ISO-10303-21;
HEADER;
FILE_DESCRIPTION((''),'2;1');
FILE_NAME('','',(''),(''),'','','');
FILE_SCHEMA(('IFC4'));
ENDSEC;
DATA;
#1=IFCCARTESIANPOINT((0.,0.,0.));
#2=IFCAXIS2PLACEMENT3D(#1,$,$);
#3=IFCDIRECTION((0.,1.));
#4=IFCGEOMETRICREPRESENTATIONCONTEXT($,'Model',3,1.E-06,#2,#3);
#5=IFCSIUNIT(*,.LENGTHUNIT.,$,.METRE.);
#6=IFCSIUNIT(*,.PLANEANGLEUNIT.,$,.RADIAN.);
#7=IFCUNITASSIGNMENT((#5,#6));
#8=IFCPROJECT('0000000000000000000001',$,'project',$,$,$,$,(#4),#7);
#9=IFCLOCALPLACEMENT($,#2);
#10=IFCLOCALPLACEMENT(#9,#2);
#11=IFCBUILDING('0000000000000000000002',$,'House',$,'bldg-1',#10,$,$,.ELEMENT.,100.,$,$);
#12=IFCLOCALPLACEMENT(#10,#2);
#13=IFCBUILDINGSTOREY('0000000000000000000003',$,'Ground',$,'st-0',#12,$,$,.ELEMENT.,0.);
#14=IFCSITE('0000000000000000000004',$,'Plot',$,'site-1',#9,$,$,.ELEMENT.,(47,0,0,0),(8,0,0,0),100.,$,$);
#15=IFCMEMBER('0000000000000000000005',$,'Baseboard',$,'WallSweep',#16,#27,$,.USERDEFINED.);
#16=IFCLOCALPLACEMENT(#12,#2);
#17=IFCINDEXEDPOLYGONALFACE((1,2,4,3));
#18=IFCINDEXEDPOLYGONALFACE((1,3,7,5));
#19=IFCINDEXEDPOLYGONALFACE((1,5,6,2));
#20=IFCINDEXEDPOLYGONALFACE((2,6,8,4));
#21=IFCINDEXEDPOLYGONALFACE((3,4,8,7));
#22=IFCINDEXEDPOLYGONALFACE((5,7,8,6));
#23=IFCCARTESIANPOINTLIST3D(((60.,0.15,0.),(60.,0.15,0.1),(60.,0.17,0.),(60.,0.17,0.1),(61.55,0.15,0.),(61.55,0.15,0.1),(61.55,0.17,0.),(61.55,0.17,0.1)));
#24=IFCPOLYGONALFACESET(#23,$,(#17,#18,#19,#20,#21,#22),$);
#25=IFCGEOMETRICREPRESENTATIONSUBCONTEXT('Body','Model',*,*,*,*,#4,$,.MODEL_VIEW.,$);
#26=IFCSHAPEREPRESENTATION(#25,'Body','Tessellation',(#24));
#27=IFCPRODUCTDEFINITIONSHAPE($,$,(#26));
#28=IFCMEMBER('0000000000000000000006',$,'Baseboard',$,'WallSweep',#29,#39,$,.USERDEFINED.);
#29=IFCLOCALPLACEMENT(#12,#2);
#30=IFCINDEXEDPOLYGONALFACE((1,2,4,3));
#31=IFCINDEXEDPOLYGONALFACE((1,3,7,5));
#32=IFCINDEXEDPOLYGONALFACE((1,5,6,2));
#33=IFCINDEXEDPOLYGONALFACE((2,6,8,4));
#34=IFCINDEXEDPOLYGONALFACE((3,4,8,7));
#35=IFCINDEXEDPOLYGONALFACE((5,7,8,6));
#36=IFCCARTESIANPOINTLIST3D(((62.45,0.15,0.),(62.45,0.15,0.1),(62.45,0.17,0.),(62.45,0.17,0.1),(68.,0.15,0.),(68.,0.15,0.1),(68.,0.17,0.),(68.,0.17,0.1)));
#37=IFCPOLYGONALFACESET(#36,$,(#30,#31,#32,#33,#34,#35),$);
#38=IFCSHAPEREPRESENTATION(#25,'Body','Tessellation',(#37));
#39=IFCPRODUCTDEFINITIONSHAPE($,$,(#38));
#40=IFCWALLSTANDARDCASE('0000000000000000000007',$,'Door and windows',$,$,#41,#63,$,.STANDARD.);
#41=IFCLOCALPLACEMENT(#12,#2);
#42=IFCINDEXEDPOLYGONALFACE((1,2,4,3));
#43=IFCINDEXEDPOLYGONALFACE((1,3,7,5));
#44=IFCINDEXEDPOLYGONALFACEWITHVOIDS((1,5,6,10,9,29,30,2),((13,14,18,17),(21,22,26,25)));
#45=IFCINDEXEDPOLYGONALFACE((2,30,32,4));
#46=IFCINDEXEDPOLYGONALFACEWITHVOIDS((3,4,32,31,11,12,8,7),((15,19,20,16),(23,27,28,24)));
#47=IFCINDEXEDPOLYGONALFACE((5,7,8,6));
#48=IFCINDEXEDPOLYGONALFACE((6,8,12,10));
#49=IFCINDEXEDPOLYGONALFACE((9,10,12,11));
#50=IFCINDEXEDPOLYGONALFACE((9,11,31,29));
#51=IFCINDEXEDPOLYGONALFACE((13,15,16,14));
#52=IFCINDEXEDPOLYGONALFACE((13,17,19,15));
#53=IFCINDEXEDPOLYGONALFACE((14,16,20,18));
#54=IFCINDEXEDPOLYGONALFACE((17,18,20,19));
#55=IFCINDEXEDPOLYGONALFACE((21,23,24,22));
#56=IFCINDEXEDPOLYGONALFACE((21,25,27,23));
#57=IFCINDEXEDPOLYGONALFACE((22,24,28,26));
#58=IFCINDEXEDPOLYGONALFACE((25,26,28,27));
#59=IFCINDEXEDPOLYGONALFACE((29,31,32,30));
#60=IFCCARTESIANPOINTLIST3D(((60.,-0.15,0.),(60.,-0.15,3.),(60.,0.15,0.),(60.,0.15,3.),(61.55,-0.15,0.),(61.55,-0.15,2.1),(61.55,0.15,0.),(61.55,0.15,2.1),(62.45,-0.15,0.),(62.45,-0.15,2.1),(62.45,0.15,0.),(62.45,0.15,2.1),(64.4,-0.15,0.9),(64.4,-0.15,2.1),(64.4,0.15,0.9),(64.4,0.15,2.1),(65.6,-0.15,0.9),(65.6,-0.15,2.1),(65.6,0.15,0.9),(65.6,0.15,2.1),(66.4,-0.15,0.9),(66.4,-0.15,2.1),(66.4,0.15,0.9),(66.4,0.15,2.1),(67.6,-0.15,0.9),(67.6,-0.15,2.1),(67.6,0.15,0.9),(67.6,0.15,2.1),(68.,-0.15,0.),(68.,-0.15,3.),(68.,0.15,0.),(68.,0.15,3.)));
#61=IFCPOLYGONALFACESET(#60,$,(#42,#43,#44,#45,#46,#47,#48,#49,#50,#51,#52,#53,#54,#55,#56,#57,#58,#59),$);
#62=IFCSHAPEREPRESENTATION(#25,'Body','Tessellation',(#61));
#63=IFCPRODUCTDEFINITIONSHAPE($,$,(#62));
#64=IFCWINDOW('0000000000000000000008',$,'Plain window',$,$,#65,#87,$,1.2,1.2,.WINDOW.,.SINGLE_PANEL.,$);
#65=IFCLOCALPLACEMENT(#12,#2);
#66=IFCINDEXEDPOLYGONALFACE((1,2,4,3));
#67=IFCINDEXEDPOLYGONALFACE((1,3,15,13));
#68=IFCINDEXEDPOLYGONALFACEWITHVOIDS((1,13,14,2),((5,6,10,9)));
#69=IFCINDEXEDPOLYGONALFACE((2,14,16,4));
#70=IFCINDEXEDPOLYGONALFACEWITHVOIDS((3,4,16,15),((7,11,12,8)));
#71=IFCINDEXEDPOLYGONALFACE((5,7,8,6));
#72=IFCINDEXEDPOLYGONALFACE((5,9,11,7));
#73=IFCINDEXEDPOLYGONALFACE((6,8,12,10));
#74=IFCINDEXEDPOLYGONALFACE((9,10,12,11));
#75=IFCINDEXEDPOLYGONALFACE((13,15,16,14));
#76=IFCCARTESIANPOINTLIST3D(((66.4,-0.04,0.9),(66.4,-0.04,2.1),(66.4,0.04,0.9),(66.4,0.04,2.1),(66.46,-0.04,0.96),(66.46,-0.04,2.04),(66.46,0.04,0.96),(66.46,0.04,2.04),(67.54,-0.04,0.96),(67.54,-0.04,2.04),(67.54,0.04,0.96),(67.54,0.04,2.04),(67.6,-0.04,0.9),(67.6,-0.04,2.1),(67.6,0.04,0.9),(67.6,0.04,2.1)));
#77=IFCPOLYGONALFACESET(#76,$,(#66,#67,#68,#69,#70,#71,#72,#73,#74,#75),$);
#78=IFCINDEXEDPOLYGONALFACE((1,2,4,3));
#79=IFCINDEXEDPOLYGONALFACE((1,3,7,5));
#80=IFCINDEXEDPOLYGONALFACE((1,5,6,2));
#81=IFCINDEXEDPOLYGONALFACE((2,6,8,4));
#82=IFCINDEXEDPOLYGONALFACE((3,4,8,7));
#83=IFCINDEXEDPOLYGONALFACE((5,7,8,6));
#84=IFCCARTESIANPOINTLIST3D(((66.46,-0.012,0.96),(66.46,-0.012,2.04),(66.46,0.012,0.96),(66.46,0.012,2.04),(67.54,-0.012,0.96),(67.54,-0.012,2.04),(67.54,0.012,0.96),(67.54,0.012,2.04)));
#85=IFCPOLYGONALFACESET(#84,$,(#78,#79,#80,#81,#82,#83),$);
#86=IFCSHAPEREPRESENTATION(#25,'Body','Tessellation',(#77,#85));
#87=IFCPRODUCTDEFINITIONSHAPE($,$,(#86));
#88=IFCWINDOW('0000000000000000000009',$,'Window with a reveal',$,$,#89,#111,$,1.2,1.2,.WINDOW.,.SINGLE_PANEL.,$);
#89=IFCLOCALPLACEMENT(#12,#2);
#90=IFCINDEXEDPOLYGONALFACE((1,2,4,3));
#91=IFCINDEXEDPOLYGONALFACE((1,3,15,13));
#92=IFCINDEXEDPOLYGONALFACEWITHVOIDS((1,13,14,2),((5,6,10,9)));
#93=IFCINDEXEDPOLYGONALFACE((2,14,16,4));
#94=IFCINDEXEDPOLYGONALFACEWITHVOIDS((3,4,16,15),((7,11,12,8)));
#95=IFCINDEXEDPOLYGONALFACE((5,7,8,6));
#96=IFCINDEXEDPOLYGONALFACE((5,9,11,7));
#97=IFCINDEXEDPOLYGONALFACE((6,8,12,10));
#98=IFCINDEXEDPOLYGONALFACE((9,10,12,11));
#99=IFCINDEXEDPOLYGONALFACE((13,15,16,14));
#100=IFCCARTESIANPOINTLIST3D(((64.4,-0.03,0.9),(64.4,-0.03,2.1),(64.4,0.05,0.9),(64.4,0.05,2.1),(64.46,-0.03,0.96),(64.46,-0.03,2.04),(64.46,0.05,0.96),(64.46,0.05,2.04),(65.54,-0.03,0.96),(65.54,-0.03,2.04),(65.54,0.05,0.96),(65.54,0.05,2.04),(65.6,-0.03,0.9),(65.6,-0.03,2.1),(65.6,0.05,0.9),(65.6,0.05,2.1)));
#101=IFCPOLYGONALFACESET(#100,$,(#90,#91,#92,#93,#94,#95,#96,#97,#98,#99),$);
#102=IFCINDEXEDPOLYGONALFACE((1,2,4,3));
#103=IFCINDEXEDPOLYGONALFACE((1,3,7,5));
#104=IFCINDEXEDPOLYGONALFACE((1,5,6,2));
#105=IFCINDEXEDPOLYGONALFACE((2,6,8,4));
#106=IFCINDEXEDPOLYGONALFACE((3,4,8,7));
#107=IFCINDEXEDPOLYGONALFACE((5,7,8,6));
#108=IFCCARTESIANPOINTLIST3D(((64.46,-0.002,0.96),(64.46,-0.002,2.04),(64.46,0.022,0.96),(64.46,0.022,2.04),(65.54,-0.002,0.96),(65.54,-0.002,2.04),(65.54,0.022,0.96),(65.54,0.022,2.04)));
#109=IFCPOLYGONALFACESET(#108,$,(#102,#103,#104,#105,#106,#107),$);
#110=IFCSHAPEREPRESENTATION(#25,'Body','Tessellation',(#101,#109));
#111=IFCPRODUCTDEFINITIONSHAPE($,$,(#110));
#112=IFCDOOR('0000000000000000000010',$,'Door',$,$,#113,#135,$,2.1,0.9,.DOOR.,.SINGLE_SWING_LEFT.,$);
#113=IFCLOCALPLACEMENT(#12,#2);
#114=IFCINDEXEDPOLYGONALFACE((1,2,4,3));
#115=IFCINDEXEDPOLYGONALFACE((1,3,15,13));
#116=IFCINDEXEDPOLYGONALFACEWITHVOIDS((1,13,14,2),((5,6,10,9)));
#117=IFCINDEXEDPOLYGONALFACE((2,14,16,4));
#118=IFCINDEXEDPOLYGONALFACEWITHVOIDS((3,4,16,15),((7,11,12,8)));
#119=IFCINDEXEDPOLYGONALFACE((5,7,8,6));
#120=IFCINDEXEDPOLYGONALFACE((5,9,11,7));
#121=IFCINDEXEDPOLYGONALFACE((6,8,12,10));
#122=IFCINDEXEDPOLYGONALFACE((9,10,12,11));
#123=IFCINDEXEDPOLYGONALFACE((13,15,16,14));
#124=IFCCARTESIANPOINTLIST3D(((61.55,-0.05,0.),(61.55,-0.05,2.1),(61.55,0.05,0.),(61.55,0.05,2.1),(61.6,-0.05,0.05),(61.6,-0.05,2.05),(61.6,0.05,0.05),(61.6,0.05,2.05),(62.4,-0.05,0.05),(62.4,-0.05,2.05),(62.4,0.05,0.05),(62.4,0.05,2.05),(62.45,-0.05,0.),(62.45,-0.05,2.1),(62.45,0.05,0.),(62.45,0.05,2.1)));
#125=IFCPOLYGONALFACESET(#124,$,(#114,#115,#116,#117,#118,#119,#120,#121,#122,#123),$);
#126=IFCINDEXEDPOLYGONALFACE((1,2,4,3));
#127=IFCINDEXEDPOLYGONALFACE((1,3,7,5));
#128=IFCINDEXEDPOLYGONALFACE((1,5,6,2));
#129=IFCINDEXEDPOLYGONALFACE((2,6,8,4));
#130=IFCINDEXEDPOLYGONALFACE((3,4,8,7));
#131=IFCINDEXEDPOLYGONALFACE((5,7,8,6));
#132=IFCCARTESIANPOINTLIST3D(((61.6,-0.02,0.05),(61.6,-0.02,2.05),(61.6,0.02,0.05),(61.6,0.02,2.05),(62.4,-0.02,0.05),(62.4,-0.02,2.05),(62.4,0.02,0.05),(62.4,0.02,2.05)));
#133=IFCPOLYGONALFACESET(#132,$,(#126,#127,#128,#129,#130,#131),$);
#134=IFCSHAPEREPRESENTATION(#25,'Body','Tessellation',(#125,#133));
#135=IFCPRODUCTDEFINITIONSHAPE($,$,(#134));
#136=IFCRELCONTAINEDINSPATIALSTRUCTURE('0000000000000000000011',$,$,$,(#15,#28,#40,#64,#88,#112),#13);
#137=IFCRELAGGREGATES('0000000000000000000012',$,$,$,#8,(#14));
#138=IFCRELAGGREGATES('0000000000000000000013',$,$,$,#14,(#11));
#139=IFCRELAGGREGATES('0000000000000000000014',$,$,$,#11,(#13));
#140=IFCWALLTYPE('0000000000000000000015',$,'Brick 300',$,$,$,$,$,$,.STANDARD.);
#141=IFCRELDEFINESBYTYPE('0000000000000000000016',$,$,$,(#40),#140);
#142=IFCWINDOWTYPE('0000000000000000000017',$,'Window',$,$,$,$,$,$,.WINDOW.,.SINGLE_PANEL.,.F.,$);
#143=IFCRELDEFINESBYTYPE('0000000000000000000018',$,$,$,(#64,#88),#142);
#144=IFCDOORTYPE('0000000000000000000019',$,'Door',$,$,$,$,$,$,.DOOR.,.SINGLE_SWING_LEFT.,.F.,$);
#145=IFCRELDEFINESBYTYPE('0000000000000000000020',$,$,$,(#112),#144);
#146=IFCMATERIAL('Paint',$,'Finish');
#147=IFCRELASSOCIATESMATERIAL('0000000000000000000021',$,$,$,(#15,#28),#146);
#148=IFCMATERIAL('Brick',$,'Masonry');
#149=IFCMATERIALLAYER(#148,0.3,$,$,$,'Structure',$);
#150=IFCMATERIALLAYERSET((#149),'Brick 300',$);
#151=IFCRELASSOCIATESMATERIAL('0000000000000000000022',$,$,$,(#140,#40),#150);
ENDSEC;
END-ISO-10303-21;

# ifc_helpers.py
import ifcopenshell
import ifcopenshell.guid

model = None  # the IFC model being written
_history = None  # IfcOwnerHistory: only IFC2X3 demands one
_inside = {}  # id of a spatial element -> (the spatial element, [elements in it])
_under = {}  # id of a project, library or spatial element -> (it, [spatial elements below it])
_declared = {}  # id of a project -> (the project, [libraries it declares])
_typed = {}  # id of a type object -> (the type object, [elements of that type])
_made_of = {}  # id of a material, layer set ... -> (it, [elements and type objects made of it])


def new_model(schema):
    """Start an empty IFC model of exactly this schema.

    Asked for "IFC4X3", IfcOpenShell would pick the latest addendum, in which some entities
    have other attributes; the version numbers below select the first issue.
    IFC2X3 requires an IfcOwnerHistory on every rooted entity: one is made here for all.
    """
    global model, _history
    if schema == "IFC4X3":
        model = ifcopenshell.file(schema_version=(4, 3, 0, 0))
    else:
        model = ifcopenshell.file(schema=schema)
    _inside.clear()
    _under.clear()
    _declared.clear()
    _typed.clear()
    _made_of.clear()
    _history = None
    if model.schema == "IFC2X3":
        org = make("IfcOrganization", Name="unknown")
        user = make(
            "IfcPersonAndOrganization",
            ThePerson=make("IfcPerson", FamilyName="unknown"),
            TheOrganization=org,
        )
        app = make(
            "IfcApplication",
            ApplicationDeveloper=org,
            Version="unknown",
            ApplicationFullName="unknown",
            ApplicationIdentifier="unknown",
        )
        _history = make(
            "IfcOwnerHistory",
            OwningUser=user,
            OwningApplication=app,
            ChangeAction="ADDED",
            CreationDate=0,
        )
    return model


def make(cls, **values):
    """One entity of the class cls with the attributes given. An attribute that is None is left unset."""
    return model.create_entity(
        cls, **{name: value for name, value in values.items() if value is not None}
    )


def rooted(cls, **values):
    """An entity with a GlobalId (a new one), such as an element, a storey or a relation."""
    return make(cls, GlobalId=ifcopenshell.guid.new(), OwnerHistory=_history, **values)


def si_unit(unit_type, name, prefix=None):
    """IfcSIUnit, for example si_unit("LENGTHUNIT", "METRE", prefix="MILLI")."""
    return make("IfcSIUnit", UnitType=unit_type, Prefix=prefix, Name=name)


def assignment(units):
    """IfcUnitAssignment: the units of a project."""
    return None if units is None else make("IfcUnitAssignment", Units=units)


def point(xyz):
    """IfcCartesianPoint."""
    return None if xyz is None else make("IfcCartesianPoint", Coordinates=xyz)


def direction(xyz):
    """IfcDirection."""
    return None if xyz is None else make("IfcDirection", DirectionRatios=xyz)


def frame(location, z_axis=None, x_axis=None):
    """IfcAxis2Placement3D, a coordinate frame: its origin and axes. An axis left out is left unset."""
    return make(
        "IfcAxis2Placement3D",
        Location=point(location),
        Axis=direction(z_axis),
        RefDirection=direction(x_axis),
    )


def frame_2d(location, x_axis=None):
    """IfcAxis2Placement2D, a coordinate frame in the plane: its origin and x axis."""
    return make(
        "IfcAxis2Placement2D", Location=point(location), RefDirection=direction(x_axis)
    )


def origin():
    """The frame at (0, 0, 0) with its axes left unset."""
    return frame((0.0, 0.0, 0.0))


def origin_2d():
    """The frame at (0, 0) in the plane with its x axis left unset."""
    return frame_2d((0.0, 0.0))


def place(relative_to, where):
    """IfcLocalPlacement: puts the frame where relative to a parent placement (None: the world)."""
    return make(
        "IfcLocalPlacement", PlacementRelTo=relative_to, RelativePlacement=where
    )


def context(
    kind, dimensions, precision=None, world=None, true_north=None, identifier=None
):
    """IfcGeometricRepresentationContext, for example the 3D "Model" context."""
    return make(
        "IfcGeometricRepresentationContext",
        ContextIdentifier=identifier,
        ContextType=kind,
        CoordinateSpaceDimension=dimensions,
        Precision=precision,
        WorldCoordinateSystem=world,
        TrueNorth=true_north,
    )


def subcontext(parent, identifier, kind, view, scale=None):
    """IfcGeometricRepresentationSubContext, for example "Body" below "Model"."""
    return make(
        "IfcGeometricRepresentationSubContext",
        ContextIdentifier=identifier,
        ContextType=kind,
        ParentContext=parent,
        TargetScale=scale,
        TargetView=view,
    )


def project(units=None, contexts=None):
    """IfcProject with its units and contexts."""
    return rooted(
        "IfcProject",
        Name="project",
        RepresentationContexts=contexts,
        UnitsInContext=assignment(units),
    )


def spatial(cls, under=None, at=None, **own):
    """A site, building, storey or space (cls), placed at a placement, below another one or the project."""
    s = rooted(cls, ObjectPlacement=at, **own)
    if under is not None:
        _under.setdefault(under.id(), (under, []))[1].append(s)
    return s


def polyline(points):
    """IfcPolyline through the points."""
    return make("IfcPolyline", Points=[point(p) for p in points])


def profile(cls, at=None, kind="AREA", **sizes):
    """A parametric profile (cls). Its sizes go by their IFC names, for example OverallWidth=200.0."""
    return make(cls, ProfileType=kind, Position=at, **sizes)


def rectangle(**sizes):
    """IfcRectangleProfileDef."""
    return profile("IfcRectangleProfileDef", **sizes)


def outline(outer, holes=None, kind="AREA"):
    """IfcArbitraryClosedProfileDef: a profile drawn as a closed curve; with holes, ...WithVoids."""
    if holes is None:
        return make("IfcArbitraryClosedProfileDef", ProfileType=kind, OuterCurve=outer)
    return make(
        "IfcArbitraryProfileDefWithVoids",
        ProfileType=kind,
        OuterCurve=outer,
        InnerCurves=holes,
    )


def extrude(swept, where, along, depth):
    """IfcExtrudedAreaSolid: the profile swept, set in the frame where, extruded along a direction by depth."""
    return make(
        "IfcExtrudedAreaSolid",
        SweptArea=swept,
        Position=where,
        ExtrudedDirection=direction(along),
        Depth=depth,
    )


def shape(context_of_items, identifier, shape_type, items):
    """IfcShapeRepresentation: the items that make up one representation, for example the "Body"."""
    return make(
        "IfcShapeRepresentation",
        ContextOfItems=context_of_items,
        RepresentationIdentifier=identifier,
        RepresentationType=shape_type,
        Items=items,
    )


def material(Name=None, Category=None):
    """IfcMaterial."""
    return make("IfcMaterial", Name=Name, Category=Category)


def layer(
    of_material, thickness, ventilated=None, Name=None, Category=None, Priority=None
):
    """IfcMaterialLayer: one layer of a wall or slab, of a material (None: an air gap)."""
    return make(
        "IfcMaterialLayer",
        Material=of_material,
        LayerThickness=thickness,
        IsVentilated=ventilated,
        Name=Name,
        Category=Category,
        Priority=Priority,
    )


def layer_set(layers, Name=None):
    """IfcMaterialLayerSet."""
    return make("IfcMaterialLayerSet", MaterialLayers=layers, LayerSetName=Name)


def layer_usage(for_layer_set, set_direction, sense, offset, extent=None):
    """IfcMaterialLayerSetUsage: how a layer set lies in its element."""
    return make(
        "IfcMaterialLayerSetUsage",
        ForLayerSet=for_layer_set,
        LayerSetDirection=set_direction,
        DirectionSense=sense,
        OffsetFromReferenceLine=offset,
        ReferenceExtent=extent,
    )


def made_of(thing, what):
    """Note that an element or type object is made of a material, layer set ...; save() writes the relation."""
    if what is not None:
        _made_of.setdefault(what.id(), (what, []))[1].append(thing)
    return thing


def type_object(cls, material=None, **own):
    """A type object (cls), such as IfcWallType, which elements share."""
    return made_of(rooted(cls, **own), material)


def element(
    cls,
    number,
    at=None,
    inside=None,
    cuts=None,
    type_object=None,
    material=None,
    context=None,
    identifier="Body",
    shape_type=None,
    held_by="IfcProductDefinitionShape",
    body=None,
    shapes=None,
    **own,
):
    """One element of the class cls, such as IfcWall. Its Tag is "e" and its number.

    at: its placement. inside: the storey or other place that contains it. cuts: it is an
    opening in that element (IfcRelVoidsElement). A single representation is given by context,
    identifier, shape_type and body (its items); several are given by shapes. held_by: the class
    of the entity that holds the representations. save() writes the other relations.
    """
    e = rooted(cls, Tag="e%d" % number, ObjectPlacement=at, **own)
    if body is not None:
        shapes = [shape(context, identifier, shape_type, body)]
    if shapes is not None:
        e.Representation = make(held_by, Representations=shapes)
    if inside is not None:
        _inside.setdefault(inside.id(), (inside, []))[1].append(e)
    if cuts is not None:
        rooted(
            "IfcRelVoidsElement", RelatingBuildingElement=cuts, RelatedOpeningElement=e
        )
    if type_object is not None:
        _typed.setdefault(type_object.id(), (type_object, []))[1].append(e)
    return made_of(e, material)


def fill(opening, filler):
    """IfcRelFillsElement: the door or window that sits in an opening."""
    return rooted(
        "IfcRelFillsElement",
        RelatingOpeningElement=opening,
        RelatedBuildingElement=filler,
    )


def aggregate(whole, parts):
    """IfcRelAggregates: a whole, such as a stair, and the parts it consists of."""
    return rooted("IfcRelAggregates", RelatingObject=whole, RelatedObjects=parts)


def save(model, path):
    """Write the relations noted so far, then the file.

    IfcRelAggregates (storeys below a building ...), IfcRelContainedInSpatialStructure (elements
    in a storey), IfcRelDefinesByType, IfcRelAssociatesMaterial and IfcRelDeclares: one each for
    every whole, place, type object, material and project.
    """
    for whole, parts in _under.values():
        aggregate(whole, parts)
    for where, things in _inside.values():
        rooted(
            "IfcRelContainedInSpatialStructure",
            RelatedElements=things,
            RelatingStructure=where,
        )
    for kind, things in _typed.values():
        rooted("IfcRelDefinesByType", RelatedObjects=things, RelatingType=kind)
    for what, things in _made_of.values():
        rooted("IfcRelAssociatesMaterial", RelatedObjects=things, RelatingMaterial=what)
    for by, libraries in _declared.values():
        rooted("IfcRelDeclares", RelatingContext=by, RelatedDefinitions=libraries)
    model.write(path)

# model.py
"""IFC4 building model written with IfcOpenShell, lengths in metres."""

from ifc_helpers import new_model, si_unit, direction, frame, frame_2d, origin, origin_2d, place, context, subcontext, project, spatial, polyline, rectangle, outline, extrude, material, layer, layer_set, layer_usage, type_object, element, fill, save


model = new_model("IFC4")

# Units and contexts
model_context = context("Model", 3, precision=1e-06, world=origin(), true_north=direction((0.0, 1.0)))
body_context = subcontext(model_context, "Body", "Model", "MODEL_VIEW")
ifc_project = project(units=[si_unit("LENGTHUNIT", "METRE"), si_unit("PLANEANGLEUNIT", "RADIAN")], contexts=[model_context])

# Site, building, storey
site_placement = place(None, origin())
site = spatial("IfcSite", under=ifc_project, at=site_placement, Name="Plot", ObjectType="site-1", CompositionType="ELEMENT", RefLatitude=(47, 0, 0, 0), RefLongitude=(8, 0, 0, 0), RefElevation=100.0)
building_placement = place(site_placement, origin())
building = spatial("IfcBuilding", under=site, at=building_placement, Name="House", ObjectType="bldg-1", CompositionType="ELEMENT", ElevationOfRefHeight=100.0)
storey_placement = place(building_placement, origin())
storey = spatial("IfcBuildingStorey", under=building, at=storey_placement, Name="Ground", ObjectType="st-0", CompositionType="ELEMENT", Elevation=0.0)

# Members
ifc_material_1 = material(Name="Paint", Category="Finish")
member_1_placement = place(storey_placement, origin())
element("IfcMember", 1, at=member_1_placement, inside=storey, material=ifc_material_1, Name="Baseboard", ObjectType="WallSweep", PredefinedType="USERDEFINED", context=body_context, shape_type="SweptSolid", body=[
    extrude(outline(polyline([(0.0, 0.0), (0.02, 0.0), (0.02, 0.1), (0.0, 0.1), (0.0, 0.0)])), frame((60.0, 0.15, 0.0), z_axis=(1.0, 0.0, 0.0), x_axis=(0.0, 1.0, 0.0)), (0.0, 0.0, 1.0), 1.55),
])
member_2_placement = place(storey_placement, origin())
element("IfcMember", 2, at=member_2_placement, inside=storey, material=ifc_material_1, Name="Baseboard", ObjectType="WallSweep", PredefinedType="USERDEFINED", context=body_context, shape_type="SweptSolid", body=[
    extrude(outline(polyline([(0.0, 0.0), (0.02, 0.0), (0.02, 0.1), (0.0, 0.1), (0.0, 0.0)])), frame((62.45, 0.15, 0.0), z_axis=(1.0, 0.0, 0.0), x_axis=(0.0, 1.0, 0.0)), (0.0, 0.0, 1.0), 5.55),
])

# Wall, openings, windows, door
ifc_material_2 = material(Name="Brick", Category="Masonry")
ifc_layer = layer(ifc_material_2, 0.3, Category="Structure")
ifc_layer_set = layer_set([ifc_layer], Name="Brick 300")
ifc_layer_usage = layer_usage(ifc_layer_set, "AXIS2", "NEGATIVE", 0.15)
wall_type = type_object("IfcWallType", Name="Brick 300", PredefinedType="STANDARD", material=ifc_layer_set)
wall_placement = place(storey_placement, frame((60.0, 0.0, 0.0), z_axis=(0.0, 0.0, 1.0), x_axis=(1.0, 0.0, 0.0)))
wall = element("IfcWallStandardCase", 3, at=wall_placement, inside=storey, type_object=wall_type, material=ifc_layer_usage, Name="Door and windows", PredefinedType="STANDARD", context=body_context, shape_type="SweptSolid", body=[
    extrude(rectangle(XDim=8.0, YDim=0.3, at=frame_2d((4.0, 0.0))), origin(), (0.0, 0.0, 1.0), 3.0),
])
opening_1_placement = place(wall_placement, frame((2.0, 0.0, 0.0)))
opening_1 = element("IfcOpeningElement", 4, at=opening_1_placement, cuts=wall, PredefinedType="OPENING", context=body_context, shape_type="SweptSolid", body=[
    extrude(rectangle(XDim=0.9, YDim=0.3, at=origin_2d()), origin(), (0.0, 0.0, 1.0), 2.1),
])
opening_2_placement = place(wall_placement, frame((7.0, 0.0, 0.9)))
opening_2 = element("IfcOpeningElement", 5, at=opening_2_placement, cuts=wall, PredefinedType="OPENING", context=body_context, shape_type="SweptSolid", body=[
    extrude(rectangle(XDim=1.2, YDim=0.3, at=origin_2d()), origin(), (0.0, 0.0, 1.0), 1.2),
])
opening_3_placement = place(wall_placement, frame((5.0, 0.0, 0.9)))
opening_3 = element("IfcOpeningElement", 6, at=opening_3_placement, cuts=wall, PredefinedType="OPENING", context=body_context, shape_type="SweptSolid", body=[
    extrude(rectangle(XDim=1.2, YDim=0.3, at=origin_2d()), origin(), (0.0, 0.0, 1.0), 1.2),
])
window_type = type_object("IfcWindowType", Name="Window", ParameterTakesPrecedence=False, PartitioningType="SINGLE_PANEL", PredefinedType="WINDOW")
window_1_placement = place(opening_2_placement, frame((0.0, 0.0, 0.0), z_axis=(0.0, -1.0, 0.0), x_axis=(1.0, 0.0, 0.0)))
window_1 = element("IfcWindow", 7, at=window_1_placement, inside=storey, type_object=window_type, Name="Plain window", OverallHeight=1.2, OverallWidth=1.2, PartitioningType="SINGLE_PANEL", PredefinedType="WINDOW", context=body_context, shape_type="SweptSolid", body=[
    extrude(outline(polyline([(-0.6, 0.0), (0.6, 0.0), (0.6, 1.2), (-0.6, 1.2), (-0.6, 0.0)]), holes=[polyline([(-0.54, 0.06), (0.54, 0.06), (0.54, 1.14), (-0.54, 1.14), (-0.54, 0.06)])]), frame((0.0, 0.0, -0.04)), (0.0, 0.0, 1.0), 0.08),
    extrude(rectangle(XDim=1.08, YDim=1.08, at=frame_2d((0.0, 0.6))), frame((0.0, 0.0, -0.012)), (0.0, 0.0, 1.0), 0.024),
])
fill(opening_2, window_1)
window_2_placement = place(opening_3_placement, frame((0.0, 0.01, 0.0), z_axis=(0.0, -1.0, 0.0), x_axis=(1.0, 0.0, 0.0)))
window_2 = element("IfcWindow", 8, at=window_2_placement, inside=storey, type_object=window_type, Name="Window with a reveal", OverallHeight=1.2, OverallWidth=1.2, PartitioningType="SINGLE_PANEL", PredefinedType="WINDOW", context=body_context, shape_type="SweptSolid", body=[
    extrude(outline(polyline([(-0.6, 0.0), (0.6, 0.0), (0.6, 1.2), (-0.6, 1.2), (-0.6, 0.0)]), holes=[polyline([(-0.54, 0.06), (0.54, 0.06), (0.54, 1.14), (-0.54, 1.14), (-0.54, 0.06)])]), frame((0.0, 0.0, -0.04)), (0.0, 0.0, 1.0), 0.08),
    extrude(rectangle(XDim=1.08, YDim=1.08, at=frame_2d((0.0, 0.6))), frame((0.0, 0.0, -0.012)), (0.0, 0.0, 1.0), 0.024),
])
fill(opening_3, window_2)
door_type = type_object("IfcDoorType", Name="Door", OperationType="SINGLE_SWING_LEFT", ParameterTakesPrecedence=False, PredefinedType="DOOR")
door_placement = place(opening_1_placement, frame((0.0, 0.0, 0.0), z_axis=(0.0, -1.0, 0.0), x_axis=(1.0, 0.0, 0.0)))
door = element("IfcDoor", 9, at=door_placement, inside=storey, type_object=door_type, Name="Door", OperationType="SINGLE_SWING_LEFT", OverallHeight=2.1, OverallWidth=0.9, PredefinedType="DOOR", context=body_context, shape_type="SweptSolid", body=[
    extrude(outline(polyline([(-0.45, 0.0), (0.45, 0.0), (0.45, 2.1), (-0.45, 2.1), (-0.45, 0.0)]), holes=[polyline([(-0.4, 0.05), (0.4, 0.05), (0.4, 2.05), (-0.4, 2.05), (-0.4, 0.05)])]), frame((0.0, 0.0, -0.05)), (0.0, 0.0, 1.0), 0.1),
    extrude(rectangle(XDim=0.8, YDim=2.0, at=frame_2d((0.0, 1.05))), frame((0.0, 0.0, -0.02)), (0.0, 0.0, 1.0), 0.04),
])
fill(opening_1, door)

save(model, "model.ifc")
